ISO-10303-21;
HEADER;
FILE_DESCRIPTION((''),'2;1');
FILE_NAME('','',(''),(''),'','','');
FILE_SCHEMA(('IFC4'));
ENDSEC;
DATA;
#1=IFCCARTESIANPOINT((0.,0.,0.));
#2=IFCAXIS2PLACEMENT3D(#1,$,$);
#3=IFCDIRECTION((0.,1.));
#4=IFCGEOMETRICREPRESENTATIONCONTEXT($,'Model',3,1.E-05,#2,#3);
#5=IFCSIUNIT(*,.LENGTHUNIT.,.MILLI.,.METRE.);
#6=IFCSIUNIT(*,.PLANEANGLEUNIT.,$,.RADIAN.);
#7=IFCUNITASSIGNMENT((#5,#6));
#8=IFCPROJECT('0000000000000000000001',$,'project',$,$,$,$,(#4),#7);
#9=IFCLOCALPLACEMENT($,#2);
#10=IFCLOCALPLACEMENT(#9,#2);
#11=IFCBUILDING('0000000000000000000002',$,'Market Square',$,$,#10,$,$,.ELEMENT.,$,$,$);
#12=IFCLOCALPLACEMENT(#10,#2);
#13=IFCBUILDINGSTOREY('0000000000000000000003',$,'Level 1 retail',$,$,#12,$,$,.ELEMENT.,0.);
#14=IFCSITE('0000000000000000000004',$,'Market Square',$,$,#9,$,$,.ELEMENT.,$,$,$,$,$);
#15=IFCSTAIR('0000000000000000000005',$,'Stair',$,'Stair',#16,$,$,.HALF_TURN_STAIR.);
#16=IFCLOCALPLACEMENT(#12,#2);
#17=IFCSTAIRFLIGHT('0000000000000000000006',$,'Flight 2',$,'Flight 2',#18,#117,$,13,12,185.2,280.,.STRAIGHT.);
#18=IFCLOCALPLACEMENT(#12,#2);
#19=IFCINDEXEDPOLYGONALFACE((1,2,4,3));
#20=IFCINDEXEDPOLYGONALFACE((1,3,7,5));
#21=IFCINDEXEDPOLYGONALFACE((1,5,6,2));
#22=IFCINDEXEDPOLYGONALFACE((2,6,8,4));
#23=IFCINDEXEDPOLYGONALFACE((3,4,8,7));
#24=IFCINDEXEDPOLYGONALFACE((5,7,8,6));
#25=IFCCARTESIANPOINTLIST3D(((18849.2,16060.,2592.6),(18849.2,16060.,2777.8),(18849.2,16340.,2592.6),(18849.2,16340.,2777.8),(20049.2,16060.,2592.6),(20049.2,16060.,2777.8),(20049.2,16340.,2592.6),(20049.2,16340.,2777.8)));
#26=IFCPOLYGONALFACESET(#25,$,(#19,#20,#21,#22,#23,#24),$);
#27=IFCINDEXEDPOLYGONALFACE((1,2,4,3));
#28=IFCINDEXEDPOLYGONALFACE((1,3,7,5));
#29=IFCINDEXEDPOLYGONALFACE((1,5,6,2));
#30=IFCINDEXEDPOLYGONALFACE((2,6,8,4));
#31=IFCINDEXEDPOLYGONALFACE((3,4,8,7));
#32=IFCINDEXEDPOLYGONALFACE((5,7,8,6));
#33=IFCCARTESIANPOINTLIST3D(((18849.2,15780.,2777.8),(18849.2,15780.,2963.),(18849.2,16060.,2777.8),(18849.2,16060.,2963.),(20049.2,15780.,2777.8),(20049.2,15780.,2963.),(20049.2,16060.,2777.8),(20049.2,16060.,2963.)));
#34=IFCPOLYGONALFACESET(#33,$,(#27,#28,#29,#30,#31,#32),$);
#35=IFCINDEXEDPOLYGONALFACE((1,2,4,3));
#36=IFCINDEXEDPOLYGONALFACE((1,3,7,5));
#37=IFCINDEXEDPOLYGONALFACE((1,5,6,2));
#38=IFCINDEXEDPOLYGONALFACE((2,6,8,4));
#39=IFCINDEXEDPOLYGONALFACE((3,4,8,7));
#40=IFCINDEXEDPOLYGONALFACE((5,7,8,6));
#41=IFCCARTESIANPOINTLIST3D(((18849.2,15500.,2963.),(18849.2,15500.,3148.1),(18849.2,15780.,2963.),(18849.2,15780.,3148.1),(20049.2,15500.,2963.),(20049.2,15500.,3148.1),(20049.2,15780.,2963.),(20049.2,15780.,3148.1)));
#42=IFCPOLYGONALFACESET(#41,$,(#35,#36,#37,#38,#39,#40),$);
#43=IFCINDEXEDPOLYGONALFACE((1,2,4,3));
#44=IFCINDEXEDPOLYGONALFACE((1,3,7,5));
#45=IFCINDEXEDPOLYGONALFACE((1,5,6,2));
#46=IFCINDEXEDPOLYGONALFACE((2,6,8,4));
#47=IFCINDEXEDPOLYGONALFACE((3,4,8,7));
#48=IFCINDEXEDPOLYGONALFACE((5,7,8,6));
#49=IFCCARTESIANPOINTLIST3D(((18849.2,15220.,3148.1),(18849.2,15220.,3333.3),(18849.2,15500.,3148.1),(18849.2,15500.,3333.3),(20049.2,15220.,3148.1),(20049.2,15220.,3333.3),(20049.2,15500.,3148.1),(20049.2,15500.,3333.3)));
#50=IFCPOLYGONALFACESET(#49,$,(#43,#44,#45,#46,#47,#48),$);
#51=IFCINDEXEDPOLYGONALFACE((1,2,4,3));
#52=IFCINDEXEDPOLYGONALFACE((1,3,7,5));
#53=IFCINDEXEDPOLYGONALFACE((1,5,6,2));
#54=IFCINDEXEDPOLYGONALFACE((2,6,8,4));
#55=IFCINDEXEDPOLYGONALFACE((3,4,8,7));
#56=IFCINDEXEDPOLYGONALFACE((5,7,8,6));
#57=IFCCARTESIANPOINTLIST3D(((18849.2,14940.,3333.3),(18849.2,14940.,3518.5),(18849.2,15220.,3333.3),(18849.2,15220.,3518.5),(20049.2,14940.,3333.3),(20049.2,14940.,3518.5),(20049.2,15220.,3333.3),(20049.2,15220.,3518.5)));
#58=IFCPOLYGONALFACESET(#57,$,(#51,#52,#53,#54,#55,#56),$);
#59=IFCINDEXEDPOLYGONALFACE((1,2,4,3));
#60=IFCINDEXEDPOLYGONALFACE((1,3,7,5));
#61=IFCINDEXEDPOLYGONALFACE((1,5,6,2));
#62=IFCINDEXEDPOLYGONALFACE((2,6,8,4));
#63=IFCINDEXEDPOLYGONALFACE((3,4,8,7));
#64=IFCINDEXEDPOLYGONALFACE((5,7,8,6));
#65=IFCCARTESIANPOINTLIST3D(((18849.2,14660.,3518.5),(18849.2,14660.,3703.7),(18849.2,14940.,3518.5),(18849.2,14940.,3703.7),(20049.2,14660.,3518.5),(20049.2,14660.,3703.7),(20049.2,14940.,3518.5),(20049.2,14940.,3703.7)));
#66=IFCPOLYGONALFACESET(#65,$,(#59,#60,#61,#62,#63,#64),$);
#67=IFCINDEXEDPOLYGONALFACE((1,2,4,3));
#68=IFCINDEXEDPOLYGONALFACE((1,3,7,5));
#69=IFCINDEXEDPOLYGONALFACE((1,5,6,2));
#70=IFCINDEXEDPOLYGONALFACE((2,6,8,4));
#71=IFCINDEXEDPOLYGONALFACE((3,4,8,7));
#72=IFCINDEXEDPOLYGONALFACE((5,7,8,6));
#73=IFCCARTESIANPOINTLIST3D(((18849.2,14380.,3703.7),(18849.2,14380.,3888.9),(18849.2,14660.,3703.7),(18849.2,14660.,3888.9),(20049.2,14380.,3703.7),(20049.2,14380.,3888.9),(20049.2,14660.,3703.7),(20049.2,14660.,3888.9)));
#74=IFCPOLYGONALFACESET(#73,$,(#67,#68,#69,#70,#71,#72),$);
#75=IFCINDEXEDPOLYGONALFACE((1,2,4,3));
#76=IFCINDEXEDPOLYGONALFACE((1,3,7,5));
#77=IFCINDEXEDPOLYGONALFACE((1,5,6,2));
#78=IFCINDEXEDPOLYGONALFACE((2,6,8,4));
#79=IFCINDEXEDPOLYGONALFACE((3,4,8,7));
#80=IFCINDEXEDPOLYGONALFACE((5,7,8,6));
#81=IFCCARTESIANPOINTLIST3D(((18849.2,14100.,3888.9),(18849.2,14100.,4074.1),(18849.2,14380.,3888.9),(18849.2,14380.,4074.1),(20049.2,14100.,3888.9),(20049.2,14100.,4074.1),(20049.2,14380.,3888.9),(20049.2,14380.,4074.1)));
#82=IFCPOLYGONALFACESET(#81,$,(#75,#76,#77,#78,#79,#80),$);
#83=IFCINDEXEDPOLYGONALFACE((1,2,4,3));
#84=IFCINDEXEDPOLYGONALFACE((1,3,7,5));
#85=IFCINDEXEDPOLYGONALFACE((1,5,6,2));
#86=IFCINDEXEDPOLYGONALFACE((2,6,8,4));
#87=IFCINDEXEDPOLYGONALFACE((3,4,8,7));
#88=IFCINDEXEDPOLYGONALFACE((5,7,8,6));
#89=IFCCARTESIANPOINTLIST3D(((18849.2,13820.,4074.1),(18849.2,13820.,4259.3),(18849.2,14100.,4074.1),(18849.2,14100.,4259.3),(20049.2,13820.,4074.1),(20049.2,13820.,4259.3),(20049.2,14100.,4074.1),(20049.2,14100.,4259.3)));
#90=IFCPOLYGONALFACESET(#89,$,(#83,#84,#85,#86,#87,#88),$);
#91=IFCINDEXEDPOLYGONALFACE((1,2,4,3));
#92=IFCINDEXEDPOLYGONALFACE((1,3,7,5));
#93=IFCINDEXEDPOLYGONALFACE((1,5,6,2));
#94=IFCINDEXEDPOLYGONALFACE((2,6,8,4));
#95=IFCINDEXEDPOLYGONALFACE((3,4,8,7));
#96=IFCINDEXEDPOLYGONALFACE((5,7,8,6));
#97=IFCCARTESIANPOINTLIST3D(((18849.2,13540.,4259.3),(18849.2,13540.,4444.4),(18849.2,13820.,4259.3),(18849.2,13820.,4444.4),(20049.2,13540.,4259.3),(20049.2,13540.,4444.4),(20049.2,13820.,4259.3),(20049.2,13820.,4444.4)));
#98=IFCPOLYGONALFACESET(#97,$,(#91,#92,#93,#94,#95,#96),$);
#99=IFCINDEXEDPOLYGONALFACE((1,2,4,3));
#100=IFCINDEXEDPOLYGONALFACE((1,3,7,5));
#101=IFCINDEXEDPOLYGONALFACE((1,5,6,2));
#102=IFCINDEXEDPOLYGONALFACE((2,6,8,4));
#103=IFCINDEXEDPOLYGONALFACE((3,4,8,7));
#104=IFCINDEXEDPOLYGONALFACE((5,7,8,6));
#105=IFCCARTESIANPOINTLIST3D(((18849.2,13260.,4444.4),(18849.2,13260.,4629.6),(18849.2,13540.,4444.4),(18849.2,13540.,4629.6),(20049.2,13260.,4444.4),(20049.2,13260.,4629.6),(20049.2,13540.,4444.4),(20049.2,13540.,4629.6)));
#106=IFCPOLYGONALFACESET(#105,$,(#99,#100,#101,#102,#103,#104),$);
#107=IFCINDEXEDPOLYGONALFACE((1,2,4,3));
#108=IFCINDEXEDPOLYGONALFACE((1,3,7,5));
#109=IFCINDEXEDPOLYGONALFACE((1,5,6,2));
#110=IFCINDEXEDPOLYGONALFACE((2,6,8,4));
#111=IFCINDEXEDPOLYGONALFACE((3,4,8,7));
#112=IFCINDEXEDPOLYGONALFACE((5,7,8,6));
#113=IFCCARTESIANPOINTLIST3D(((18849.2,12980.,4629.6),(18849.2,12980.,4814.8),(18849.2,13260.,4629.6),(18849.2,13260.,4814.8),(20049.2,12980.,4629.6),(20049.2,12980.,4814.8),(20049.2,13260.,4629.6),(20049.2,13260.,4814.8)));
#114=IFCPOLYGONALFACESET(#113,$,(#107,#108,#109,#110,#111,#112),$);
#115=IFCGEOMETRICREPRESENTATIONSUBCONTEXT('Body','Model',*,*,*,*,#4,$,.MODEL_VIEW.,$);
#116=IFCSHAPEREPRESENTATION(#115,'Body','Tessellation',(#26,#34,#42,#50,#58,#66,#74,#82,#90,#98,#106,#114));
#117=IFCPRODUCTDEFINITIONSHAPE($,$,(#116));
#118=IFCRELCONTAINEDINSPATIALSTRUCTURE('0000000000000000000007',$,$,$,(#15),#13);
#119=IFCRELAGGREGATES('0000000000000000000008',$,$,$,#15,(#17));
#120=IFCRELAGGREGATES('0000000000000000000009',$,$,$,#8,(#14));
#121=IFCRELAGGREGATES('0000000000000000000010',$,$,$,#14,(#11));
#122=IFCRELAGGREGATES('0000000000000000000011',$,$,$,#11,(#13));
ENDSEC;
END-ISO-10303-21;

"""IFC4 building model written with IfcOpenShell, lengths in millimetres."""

from ifc_helpers import new_model, si_unit, direction, frame, origin, origin_with_axes, place, context, subcontext, project, spatial, polyline, outline, extrude, element, aggregate, save


model = new_model("IFC4")

# Units and contexts
model_context = context("Model", 3, precision=1e-05, world=origin(), true_north=direction((0.0, 1.0)))
body_context = subcontext(model_context, "Body", "Model", "MODEL_VIEW")
ifc_project = project(units=[si_unit("LENGTHUNIT", "METRE", prefix="MILLI"), si_unit("PLANEANGLEUNIT", "RADIAN")], contexts=[model_context])

# Site, building, storey
site_placement = place(None, origin())
site = spatial("IfcSite", under=ifc_project, at=site_placement, Name="Market Square", CompositionType="ELEMENT")
building_placement = place(site_placement, origin())
building = spatial("IfcBuilding", under=site, at=building_placement, Name="Market Square", CompositionType="ELEMENT")
storey_placement = place(building_placement, origin())
storey = spatial("IfcBuildingStorey", under=building, at=storey_placement, Name="Level 1 retail", CompositionType="ELEMENT", Elevation=0.0)

# Stair, stair flight
stair_placement = place(storey_placement, origin_with_axes())
stair = element("IfcStair", 1, at=stair_placement, inside=storey, Name="Stair", ObjectType="Stair", PredefinedType="HALF_TURN_STAIR")
stair_flight_placement = place(storey_placement, origin_with_axes())
stair_flight = element("IfcStairFlight", 2, at=stair_flight_placement, Name="Flight 2", ObjectType="Flight 2", NumberOfRisers=13, NumberOfTreads=12, PredefinedType="STRAIGHT", RiserHeight=185.2, TreadLength=280.0, context=body_context, shape_type="SweptSolid", body=[
    extrude(outline(polyline([(20049.2, 16060.0), (20049.2, 16340.0), (18849.2, 16340.0), (18849.2, 16060.0), (20049.2, 16060.0)])), frame((0.0, 0.0, 2592.6)), (0.0, 0.0, 1.0), 185.2),
    extrude(outline(polyline([(20049.2, 15780.0), (20049.2, 16060.0), (18849.2, 16060.0), (18849.2, 15780.0), (20049.2, 15780.0)])), frame((0.0, 0.0, 2777.8)), (0.0, 0.0, 1.0), 185.2),
    extrude(outline(polyline([(20049.2, 15500.0), (20049.2, 15780.0), (18849.2, 15780.0), (18849.2, 15500.0), (20049.2, 15500.0)])), frame((0.0, 0.0, 2963.0)), (0.0, 0.0, 1.0), 185.2),
    extrude(outline(polyline([(20049.2, 15220.0), (20049.2, 15500.0), (18849.2, 15500.0), (18849.2, 15220.0), (20049.2, 15220.0)])), frame((0.0, 0.0, 3148.1)), (0.0, 0.0, 1.0), 185.2),
    extrude(outline(polyline([(20049.2, 14940.0), (20049.2, 15220.0), (18849.2, 15220.0), (18849.2, 14940.0), (20049.2, 14940.0)])), frame((0.0, 0.0, 3333.3)), (0.0, 0.0, 1.0), 185.2),
    extrude(outline(polyline([(20049.2, 14660.0), (20049.2, 14940.0), (18849.2, 14940.0), (18849.2, 14660.0), (20049.2, 14660.0)])), frame((0.0, 0.0, 3518.5)), (0.0, 0.0, 1.0), 185.2),
    extrude(outline(polyline([(20049.2, 14380.0), (20049.2, 14660.0), (18849.2, 14660.0), (18849.2, 14380.0), (20049.2, 14380.0)])), frame((0.0, 0.0, 3703.7)), (0.0, 0.0, 1.0), 185.2),
    extrude(outline(polyline([(20049.2, 14100.0), (20049.2, 14380.0), (18849.2, 14380.0), (18849.2, 14100.0), (20049.2, 14100.0)])), frame((0.0, 0.0, 3888.9)), (0.0, 0.0, 1.0), 185.2),
    extrude(outline(polyline([(20049.2, 13820.0), (20049.2, 14100.0), (18849.2, 14100.0), (18849.2, 13820.0), (20049.2, 13820.0)])), frame((0.0, 0.0, 4074.1)), (0.0, 0.0, 1.0), 185.2),
    extrude(outline(polyline([(20049.2, 13540.0), (20049.2, 13820.0), (18849.2, 13820.0), (18849.2, 13540.0), (20049.2, 13540.0)])), frame((0.0, 0.0, 4259.3)), (0.0, 0.0, 1.0), 185.2),
    extrude(outline(polyline([(20049.2, 13260.0), (20049.2, 13540.0), (18849.2, 13540.0), (18849.2, 13260.0), (20049.2, 13260.0)])), frame((0.0, 0.0, 4444.4)), (0.0, 0.0, 1.0), 185.2),
    extrude(outline(polyline([(20049.2, 12980.0), (20049.2, 13260.0), (18849.2, 13260.0), (18849.2, 12980.0), (20049.2, 12980.0)])), frame((0.0, 0.0, 4629.6)), (0.0, 0.0, 1.0), 185.2),
])
aggregate(stair, [stair_flight])

save(model, "model.ifc")
